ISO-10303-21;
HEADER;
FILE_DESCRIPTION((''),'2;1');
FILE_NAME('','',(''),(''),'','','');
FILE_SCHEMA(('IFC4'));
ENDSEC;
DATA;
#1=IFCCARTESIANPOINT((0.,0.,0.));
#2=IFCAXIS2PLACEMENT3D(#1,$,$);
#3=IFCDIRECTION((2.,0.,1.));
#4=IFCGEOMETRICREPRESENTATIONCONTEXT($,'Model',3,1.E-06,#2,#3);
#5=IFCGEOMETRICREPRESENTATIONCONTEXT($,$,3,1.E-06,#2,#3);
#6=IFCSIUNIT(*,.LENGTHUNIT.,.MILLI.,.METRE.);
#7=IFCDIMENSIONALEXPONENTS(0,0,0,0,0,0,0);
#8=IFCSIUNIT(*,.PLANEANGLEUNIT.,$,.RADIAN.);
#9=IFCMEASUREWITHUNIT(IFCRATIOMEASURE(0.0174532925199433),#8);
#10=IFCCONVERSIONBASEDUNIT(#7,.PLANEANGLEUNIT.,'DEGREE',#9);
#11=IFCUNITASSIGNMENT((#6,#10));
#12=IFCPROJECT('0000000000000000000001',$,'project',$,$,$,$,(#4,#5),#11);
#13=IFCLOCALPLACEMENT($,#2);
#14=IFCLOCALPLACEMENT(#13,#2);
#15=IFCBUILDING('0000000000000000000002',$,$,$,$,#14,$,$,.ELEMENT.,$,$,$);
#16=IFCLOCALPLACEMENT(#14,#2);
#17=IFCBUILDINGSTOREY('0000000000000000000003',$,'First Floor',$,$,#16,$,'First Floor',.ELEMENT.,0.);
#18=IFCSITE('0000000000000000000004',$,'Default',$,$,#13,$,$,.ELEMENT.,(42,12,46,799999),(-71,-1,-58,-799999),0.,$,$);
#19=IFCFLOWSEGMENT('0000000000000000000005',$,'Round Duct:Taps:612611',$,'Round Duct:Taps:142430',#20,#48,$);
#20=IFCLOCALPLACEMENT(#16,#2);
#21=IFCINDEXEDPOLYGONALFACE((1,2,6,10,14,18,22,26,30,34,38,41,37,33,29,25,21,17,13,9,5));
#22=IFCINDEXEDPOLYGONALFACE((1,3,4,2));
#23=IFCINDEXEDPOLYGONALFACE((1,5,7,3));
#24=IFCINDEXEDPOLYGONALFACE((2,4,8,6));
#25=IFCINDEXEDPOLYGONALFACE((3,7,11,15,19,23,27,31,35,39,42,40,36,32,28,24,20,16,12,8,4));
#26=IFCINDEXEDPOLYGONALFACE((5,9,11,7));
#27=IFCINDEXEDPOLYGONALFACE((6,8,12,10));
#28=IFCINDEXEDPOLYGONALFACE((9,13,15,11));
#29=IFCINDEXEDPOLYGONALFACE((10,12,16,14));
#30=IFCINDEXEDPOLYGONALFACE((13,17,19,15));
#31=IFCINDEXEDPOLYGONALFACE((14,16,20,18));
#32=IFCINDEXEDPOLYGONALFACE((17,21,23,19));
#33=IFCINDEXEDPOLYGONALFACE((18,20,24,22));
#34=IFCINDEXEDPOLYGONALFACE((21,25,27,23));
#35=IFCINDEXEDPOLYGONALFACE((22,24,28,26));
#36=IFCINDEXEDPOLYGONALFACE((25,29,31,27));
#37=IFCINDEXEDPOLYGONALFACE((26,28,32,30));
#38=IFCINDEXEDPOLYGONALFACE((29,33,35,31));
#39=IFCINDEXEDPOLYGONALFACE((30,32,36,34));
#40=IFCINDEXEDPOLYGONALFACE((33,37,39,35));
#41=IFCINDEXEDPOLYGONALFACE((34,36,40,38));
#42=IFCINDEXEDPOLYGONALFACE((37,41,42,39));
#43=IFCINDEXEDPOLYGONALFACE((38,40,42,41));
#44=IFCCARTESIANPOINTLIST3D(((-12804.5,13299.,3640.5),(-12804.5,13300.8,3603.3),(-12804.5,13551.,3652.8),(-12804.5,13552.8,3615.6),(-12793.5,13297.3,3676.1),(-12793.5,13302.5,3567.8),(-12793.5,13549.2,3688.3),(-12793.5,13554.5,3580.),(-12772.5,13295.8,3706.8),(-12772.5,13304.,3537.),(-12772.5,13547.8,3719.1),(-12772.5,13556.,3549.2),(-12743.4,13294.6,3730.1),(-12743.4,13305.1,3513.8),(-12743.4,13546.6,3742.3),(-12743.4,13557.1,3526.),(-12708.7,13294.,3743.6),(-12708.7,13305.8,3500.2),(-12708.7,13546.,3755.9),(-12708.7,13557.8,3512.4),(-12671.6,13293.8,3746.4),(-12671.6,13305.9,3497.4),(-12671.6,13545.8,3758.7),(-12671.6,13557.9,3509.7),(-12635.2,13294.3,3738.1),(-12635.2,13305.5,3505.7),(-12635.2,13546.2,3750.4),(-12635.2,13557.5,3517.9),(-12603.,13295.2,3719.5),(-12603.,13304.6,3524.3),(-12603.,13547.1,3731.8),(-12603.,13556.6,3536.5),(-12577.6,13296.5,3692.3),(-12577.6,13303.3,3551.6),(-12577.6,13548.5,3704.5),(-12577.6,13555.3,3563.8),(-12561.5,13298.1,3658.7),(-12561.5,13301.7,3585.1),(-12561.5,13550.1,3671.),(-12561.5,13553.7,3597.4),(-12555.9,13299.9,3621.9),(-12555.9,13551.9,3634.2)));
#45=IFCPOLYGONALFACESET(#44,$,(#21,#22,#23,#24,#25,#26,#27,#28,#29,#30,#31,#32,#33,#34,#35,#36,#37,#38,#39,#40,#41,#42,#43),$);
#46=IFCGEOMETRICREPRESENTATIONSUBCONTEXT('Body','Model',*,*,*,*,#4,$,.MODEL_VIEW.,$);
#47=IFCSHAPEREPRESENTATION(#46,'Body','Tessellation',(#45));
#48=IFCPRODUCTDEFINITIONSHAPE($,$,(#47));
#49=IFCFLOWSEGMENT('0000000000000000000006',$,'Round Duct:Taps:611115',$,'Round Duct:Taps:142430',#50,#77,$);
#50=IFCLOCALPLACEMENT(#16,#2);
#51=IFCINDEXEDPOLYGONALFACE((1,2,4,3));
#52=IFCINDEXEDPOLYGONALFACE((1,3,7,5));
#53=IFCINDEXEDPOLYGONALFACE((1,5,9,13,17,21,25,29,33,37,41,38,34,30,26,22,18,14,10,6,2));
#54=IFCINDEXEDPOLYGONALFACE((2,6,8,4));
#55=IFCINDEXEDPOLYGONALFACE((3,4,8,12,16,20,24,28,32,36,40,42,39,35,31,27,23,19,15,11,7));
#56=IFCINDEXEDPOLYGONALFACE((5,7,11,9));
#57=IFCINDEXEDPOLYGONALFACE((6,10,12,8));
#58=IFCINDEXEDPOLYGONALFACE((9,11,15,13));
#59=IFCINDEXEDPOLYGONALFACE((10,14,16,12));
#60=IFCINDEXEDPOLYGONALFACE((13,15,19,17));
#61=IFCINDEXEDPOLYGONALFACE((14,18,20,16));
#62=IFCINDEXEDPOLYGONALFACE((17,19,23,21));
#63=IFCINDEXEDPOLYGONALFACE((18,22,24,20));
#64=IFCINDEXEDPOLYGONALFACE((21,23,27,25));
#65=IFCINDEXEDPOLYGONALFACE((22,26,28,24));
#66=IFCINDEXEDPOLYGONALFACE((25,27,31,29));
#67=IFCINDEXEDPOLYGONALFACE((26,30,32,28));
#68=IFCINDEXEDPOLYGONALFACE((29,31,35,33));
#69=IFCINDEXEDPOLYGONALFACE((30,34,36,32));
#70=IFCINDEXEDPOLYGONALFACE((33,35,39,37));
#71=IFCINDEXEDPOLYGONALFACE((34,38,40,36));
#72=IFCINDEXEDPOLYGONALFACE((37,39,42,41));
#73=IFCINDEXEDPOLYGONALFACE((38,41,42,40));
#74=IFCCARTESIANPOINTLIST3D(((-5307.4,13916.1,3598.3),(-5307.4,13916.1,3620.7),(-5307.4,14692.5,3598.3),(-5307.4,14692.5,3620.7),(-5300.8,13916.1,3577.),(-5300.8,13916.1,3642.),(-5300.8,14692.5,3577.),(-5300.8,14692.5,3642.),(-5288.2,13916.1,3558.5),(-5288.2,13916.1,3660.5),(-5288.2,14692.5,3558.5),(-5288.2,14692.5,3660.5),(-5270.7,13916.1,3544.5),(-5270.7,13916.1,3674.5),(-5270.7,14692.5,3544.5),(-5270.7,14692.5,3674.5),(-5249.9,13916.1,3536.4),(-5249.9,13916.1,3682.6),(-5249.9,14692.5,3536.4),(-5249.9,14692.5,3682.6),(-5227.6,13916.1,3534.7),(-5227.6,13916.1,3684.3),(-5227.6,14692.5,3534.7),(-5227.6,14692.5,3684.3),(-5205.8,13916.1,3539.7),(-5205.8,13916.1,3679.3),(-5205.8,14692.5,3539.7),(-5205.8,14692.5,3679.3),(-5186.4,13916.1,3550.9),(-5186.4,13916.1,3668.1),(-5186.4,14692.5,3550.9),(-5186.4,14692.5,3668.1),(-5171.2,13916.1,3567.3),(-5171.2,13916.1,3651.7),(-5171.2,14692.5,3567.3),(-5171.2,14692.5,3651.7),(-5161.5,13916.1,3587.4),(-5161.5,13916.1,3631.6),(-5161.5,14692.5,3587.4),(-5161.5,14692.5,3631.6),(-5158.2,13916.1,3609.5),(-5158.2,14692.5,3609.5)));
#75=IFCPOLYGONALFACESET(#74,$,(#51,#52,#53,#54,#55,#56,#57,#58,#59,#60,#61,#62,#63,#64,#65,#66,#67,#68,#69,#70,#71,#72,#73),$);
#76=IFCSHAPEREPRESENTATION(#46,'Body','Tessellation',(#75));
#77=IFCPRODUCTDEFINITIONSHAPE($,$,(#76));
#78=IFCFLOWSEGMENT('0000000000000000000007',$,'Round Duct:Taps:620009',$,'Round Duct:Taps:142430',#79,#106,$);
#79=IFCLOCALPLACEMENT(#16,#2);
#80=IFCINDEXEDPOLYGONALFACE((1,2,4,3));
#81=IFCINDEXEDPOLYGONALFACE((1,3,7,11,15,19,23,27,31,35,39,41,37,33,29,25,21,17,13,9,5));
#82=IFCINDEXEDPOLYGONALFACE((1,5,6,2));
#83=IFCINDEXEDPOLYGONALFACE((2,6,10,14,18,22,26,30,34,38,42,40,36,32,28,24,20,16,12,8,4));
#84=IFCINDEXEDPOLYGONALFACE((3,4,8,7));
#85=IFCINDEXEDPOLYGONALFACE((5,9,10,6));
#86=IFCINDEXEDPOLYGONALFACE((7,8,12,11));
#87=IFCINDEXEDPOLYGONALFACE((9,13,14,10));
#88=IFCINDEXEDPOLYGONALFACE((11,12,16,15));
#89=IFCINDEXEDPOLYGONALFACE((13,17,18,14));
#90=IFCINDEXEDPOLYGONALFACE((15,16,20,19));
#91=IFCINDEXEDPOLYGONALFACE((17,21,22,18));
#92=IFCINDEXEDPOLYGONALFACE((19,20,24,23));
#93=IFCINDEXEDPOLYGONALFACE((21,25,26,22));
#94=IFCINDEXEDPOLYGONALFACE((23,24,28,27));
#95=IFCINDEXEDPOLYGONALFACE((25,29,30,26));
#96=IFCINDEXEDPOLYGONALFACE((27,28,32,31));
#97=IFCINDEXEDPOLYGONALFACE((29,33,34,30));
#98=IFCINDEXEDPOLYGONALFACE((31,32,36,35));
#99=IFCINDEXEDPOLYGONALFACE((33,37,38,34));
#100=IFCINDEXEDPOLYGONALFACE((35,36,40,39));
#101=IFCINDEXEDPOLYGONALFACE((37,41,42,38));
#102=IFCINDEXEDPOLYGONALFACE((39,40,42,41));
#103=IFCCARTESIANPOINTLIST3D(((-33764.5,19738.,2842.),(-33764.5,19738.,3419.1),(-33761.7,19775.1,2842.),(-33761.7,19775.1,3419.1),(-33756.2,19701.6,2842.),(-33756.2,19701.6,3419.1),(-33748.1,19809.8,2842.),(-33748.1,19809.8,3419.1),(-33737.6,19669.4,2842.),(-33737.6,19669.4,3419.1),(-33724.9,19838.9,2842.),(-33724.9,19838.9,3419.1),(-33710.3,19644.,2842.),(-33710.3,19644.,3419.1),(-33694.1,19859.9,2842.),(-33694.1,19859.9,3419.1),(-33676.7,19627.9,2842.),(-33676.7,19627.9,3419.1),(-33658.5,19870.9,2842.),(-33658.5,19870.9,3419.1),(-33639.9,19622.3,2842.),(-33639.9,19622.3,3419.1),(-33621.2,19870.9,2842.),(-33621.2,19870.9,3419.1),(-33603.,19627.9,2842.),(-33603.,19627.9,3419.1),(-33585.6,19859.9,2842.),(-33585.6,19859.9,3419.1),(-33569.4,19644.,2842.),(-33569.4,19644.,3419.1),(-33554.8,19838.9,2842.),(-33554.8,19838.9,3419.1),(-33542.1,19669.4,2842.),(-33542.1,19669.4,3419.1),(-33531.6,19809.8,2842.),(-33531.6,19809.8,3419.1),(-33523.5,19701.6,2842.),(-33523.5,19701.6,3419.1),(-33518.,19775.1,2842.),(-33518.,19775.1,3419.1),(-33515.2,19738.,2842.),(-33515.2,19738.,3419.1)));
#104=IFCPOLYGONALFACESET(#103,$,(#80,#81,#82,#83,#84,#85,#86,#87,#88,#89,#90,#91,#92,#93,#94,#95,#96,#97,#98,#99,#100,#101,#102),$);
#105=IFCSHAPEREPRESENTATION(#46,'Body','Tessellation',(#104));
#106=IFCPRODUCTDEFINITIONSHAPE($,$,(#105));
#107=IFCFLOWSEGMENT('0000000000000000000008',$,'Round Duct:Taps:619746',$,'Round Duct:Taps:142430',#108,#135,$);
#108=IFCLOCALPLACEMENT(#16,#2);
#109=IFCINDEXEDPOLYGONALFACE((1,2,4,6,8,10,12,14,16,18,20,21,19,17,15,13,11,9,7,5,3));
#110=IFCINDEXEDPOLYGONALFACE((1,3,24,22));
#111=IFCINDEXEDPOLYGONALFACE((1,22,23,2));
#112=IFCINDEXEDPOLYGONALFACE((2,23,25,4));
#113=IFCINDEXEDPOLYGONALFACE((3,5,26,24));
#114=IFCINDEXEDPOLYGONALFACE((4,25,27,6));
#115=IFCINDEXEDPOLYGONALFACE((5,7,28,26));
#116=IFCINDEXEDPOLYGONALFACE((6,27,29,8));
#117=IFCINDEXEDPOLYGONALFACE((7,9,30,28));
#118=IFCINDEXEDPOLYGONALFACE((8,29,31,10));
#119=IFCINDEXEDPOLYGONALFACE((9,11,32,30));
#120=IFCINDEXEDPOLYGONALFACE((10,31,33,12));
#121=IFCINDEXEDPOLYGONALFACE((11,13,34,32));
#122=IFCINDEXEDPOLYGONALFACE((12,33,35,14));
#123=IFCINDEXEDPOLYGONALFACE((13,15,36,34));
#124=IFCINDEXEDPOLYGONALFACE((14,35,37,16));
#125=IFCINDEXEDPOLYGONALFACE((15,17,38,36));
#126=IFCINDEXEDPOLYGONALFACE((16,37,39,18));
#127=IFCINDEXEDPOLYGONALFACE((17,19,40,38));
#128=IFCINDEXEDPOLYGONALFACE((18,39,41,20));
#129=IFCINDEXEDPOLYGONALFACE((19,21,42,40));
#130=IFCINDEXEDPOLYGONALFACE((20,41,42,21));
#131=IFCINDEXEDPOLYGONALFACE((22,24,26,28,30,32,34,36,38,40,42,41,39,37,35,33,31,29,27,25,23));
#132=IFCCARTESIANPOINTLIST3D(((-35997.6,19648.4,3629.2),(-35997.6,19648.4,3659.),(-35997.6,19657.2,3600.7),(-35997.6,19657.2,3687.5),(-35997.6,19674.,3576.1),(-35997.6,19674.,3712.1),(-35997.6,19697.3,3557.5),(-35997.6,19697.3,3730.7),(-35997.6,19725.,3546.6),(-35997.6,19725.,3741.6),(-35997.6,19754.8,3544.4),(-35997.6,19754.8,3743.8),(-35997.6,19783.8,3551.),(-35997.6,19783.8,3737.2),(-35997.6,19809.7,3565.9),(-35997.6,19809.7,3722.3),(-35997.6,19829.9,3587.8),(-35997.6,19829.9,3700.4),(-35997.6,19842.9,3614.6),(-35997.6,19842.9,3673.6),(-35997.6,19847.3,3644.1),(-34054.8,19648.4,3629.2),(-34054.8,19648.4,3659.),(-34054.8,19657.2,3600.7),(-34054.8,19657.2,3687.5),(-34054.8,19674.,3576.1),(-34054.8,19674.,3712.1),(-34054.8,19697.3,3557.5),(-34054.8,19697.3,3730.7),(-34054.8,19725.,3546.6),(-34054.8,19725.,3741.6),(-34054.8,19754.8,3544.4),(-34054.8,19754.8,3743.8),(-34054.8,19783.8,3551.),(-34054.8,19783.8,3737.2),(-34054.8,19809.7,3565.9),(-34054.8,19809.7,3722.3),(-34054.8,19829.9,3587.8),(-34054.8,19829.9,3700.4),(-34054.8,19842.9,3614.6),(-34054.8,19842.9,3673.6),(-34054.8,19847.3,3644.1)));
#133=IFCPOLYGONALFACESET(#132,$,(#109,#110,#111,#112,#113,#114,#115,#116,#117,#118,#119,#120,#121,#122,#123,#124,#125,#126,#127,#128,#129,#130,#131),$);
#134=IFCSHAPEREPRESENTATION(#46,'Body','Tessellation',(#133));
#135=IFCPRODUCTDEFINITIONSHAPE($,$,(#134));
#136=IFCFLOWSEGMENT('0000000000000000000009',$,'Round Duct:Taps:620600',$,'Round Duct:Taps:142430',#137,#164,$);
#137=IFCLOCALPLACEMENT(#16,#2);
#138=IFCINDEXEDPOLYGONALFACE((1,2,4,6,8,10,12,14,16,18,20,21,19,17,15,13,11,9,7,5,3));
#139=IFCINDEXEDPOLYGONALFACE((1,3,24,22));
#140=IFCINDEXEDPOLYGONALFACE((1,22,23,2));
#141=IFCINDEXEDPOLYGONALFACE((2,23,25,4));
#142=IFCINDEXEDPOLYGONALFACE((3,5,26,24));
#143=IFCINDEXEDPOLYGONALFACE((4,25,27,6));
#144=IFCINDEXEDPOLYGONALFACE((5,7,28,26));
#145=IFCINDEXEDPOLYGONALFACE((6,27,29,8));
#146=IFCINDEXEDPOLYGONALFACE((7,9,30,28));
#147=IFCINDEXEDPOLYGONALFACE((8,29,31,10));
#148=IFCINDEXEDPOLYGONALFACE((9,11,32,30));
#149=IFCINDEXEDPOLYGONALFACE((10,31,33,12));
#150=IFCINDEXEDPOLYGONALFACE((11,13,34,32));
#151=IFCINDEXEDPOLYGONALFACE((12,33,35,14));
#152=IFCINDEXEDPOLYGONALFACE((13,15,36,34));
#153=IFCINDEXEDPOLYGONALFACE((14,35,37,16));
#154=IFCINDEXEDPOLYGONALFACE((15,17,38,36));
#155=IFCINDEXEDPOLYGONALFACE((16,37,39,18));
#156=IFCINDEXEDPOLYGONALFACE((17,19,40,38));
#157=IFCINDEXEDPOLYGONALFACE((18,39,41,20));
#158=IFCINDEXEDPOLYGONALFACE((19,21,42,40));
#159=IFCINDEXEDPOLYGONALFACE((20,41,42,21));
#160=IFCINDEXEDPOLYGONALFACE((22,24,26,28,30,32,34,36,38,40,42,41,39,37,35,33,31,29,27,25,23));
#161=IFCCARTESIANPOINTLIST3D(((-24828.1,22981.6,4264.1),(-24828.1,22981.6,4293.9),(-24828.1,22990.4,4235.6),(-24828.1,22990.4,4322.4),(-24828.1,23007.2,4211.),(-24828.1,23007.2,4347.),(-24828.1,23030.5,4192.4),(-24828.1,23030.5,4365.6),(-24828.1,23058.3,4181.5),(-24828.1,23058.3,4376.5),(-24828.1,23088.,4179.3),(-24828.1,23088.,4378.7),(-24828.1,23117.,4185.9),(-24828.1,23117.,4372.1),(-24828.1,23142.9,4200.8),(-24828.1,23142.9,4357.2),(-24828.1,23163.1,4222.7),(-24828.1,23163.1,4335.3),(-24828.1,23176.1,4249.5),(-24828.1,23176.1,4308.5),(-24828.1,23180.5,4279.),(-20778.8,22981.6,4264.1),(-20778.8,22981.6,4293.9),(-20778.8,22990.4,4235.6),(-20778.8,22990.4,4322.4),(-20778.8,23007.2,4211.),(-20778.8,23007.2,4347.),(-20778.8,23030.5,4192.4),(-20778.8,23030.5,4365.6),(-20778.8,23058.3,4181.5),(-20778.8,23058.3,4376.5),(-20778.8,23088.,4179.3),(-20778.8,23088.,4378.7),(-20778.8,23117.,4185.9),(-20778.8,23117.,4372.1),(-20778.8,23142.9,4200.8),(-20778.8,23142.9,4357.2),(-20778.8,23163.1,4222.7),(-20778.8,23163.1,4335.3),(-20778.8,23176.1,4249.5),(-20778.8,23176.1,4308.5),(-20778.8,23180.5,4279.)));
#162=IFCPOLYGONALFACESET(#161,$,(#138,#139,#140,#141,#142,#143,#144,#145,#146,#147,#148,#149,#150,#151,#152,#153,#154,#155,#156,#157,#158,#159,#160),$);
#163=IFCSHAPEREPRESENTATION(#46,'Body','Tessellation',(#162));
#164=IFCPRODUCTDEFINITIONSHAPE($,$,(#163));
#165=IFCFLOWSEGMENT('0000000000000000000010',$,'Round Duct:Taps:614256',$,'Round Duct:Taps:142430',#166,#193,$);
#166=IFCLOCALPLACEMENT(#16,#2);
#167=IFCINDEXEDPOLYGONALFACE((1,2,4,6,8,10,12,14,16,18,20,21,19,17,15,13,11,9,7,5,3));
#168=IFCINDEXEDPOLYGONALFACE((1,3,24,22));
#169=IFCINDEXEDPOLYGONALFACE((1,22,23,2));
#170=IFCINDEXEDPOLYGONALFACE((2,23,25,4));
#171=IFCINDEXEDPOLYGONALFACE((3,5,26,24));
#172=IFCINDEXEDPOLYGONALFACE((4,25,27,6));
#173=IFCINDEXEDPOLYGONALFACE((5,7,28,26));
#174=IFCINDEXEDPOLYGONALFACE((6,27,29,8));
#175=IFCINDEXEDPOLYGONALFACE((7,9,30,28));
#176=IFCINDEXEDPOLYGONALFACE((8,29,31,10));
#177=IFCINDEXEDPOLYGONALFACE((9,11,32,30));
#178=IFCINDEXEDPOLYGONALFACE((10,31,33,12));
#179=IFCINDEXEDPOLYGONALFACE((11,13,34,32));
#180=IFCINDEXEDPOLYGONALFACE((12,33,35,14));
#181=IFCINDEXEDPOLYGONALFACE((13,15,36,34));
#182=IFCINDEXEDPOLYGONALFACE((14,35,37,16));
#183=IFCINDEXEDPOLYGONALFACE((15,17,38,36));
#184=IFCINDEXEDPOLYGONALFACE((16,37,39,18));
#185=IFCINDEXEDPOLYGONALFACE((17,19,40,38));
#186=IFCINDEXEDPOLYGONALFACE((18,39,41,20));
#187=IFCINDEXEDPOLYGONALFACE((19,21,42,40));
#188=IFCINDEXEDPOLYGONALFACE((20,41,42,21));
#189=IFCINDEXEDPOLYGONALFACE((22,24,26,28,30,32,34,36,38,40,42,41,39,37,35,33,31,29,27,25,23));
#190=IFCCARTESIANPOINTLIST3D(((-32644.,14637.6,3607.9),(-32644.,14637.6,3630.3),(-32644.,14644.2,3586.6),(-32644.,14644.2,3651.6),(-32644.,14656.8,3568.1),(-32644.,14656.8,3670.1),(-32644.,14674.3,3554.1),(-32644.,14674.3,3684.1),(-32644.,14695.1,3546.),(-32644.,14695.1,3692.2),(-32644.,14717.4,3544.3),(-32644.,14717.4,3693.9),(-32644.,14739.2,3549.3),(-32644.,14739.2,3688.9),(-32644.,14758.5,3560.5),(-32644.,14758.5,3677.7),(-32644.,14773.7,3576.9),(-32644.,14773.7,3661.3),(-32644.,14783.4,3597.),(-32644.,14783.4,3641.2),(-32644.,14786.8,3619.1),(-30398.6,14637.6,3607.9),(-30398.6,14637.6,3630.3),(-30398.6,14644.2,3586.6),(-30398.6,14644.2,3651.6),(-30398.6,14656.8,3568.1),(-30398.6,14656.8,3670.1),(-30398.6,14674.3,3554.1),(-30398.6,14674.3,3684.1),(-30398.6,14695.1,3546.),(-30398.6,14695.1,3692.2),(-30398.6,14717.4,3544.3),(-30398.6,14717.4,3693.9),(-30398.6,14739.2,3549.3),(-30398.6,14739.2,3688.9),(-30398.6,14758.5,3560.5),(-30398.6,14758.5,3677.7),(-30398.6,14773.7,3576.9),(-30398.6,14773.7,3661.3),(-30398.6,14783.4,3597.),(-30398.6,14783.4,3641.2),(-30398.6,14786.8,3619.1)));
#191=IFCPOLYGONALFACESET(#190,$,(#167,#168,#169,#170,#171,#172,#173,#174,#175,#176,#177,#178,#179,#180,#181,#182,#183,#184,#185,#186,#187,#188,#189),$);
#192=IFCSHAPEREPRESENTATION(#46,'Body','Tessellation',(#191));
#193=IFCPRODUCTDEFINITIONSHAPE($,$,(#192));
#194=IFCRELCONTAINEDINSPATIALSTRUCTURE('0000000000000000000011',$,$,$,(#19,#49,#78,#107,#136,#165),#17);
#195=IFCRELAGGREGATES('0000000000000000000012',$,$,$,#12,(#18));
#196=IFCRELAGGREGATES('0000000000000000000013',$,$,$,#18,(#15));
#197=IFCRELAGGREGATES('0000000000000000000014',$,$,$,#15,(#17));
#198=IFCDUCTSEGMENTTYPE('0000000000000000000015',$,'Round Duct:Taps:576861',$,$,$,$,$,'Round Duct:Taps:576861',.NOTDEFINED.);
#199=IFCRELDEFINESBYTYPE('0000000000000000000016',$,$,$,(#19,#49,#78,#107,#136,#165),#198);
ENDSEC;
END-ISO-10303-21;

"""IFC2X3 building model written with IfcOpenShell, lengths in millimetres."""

from ifc_helpers import new_model, entity, si_unit, converted_unit, direction, frame, frame_2d, origin, origin_2d_with_axis, place, context, subcontext, project, spatial, circle, extrude, type_object, element, save


model = new_model("IFC2X3")

# Units and contexts
model_context = context("Model", 3, precision=1e-06, world=origin(), true_north=direction((2.0, 0.0, 1.0)))
context_of_model = context(None, 3, precision=1e-06, world=origin(), true_north=direction((2.0, 0.0, 1.0)))
body_context = subcontext(model_context, "Body", "Model", "MODEL_VIEW")
ifc_project = project(units=[si_unit("LENGTHUNIT", "METRE", prefix="MILLI"), converted_unit("PLANEANGLEUNIT", "DEGREE", entity("IfcRatioMeasure", 0.0174532925199433), si_unit("PLANEANGLEUNIT", "RADIAN"), dimensions=[0, 0, 0, 0, 0, 0, 0])], contexts=[model_context, context_of_model])

# Site, building, storey
site_placement = place(None, origin())
site = spatial("IfcSite", under=ifc_project, at=site_placement, Name="Default", CompositionType="ELEMENT", RefLatitude=(42, 12, 46, 799999), RefLongitude=(-71, -1, -58, -799999), RefElevation=0.0)
building_placement = place(site_placement, origin())
building = spatial("IfcBuilding", under=site, at=building_placement, CompositionType="ELEMENT")
storey_placement = place(building_placement, origin())
storey = spatial("IfcBuildingStorey", under=building, at=storey_placement, Name="First Floor", LongName="First Floor", CompositionType="ELEMENT", Elevation=0.0)

# Flow segments
duct_segment_type_1 = type_object("IfcDuctSegmentType", Name="Round Duct:Taps:576861", ElementType="Round Duct:Taps:576861", PredefinedType="NOTDEFINED")
flow_segment_1_placement = place(storey_placement, origin())
element("IfcFlowSegment", 1, at=flow_segment_1_placement, inside=storey, type_object=duct_segment_type_1, Name="Round Duct:Taps:612611", ObjectType="Round Duct:Taps:142430", context=body_context, shape_type="SweptSolid", body=[
    extrude(circle(Radius=125.0, at=frame_2d((0.0, 0.0), x_axis=(1.0, 0.0))), frame((-12680.9, 13299.9, 3621.9), z_axis=(0.0, 0.998824, 0.048491), x_axis=(1.0, 0.0, 0.0)), (0.0, 0.0, 1.0), 252.3),
])
flow_segment_2_placement = place(storey_placement, origin())
element("IfcFlowSegment", 2, at=flow_segment_2_placement, inside=storey, type_object=duct_segment_type_1, Name="Round Duct:Taps:611115", ObjectType="Round Duct:Taps:142430", context=body_context, shape_type="SweptSolid", body=[
    extrude(circle(Radius=75.0, at=origin_2d_with_axis()), frame((-5233.2, 13916.1, 3609.5), z_axis=(0.0, 1.0, 0.0), x_axis=(1.0, 0.0, 0.0)), (0.0, 0.0, 1.0), 776.4),
])
flow_segment_3_placement = place(storey_placement, origin())
element("IfcFlowSegment", 3, at=flow_segment_3_placement, inside=storey, type_object=duct_segment_type_1, Name="Round Duct:Taps:620009", ObjectType="Round Duct:Taps:142430", context=body_context, shape_type="SweptSolid", body=[
    extrude(circle(Radius=125.0, at=origin_2d_with_axis()), frame((-33639.9, 19747.3, 2842.0), z_axis=(0.0, 0.0, 1.0), x_axis=(0.0, -1.0, 0.0)), (0.0, 0.0, 1.0), 577.1),
])
flow_segment_4_placement = place(storey_placement, origin())
element("IfcFlowSegment", 4, at=flow_segment_4_placement, inside=storey, type_object=duct_segment_type_1, Name="Round Duct:Taps:619746", ObjectType="Round Duct:Taps:142430", context=body_context, shape_type="SweptSolid", body=[
    extrude(circle(Radius=100.0, at=frame_2d((0.0, 0.0), x_axis=(1.0, 0.0))), frame((-35997.6, 19747.3, 3644.1), z_axis=(1.0, 0.0, 0.0), x_axis=(0.0, 1.0, 0.0)), (0.0, 0.0, 1.0), 1942.8),
])
flow_segment_5_placement = place(storey_placement, origin())
element("IfcFlowSegment", 5, at=flow_segment_5_placement, inside=storey, type_object=duct_segment_type_1, Name="Round Duct:Taps:620600", ObjectType="Round Duct:Taps:142430", context=body_context, shape_type="SweptSolid", body=[
    extrude(circle(Radius=100.0, at=origin_2d_with_axis()), frame((-24828.1, 23080.5, 4279.0), z_axis=(1.0, 0.0, 0.0), x_axis=(0.0, 1.0, 0.0)), (0.0, 0.0, 1.0), 4049.3),
])
flow_segment_6_placement = place(storey_placement, origin())
element("IfcFlowSegment", 6, at=flow_segment_6_placement, inside=storey, type_object=duct_segment_type_1, Name="Round Duct:Taps:614256", ObjectType="Round Duct:Taps:142430", context=body_context, shape_type="SweptSolid", body=[
    extrude(circle(Radius=75.0, at=frame_2d((0.0, 0.0), x_axis=(1.0, 0.0))), frame((-32644.0, 14711.8, 3619.1), z_axis=(1.0, 0.0, 0.0), x_axis=(0.0, 1.0, 0.0)), (0.0, 0.0, 1.0), 2245.4),
])

save(model, "model.ifc")
